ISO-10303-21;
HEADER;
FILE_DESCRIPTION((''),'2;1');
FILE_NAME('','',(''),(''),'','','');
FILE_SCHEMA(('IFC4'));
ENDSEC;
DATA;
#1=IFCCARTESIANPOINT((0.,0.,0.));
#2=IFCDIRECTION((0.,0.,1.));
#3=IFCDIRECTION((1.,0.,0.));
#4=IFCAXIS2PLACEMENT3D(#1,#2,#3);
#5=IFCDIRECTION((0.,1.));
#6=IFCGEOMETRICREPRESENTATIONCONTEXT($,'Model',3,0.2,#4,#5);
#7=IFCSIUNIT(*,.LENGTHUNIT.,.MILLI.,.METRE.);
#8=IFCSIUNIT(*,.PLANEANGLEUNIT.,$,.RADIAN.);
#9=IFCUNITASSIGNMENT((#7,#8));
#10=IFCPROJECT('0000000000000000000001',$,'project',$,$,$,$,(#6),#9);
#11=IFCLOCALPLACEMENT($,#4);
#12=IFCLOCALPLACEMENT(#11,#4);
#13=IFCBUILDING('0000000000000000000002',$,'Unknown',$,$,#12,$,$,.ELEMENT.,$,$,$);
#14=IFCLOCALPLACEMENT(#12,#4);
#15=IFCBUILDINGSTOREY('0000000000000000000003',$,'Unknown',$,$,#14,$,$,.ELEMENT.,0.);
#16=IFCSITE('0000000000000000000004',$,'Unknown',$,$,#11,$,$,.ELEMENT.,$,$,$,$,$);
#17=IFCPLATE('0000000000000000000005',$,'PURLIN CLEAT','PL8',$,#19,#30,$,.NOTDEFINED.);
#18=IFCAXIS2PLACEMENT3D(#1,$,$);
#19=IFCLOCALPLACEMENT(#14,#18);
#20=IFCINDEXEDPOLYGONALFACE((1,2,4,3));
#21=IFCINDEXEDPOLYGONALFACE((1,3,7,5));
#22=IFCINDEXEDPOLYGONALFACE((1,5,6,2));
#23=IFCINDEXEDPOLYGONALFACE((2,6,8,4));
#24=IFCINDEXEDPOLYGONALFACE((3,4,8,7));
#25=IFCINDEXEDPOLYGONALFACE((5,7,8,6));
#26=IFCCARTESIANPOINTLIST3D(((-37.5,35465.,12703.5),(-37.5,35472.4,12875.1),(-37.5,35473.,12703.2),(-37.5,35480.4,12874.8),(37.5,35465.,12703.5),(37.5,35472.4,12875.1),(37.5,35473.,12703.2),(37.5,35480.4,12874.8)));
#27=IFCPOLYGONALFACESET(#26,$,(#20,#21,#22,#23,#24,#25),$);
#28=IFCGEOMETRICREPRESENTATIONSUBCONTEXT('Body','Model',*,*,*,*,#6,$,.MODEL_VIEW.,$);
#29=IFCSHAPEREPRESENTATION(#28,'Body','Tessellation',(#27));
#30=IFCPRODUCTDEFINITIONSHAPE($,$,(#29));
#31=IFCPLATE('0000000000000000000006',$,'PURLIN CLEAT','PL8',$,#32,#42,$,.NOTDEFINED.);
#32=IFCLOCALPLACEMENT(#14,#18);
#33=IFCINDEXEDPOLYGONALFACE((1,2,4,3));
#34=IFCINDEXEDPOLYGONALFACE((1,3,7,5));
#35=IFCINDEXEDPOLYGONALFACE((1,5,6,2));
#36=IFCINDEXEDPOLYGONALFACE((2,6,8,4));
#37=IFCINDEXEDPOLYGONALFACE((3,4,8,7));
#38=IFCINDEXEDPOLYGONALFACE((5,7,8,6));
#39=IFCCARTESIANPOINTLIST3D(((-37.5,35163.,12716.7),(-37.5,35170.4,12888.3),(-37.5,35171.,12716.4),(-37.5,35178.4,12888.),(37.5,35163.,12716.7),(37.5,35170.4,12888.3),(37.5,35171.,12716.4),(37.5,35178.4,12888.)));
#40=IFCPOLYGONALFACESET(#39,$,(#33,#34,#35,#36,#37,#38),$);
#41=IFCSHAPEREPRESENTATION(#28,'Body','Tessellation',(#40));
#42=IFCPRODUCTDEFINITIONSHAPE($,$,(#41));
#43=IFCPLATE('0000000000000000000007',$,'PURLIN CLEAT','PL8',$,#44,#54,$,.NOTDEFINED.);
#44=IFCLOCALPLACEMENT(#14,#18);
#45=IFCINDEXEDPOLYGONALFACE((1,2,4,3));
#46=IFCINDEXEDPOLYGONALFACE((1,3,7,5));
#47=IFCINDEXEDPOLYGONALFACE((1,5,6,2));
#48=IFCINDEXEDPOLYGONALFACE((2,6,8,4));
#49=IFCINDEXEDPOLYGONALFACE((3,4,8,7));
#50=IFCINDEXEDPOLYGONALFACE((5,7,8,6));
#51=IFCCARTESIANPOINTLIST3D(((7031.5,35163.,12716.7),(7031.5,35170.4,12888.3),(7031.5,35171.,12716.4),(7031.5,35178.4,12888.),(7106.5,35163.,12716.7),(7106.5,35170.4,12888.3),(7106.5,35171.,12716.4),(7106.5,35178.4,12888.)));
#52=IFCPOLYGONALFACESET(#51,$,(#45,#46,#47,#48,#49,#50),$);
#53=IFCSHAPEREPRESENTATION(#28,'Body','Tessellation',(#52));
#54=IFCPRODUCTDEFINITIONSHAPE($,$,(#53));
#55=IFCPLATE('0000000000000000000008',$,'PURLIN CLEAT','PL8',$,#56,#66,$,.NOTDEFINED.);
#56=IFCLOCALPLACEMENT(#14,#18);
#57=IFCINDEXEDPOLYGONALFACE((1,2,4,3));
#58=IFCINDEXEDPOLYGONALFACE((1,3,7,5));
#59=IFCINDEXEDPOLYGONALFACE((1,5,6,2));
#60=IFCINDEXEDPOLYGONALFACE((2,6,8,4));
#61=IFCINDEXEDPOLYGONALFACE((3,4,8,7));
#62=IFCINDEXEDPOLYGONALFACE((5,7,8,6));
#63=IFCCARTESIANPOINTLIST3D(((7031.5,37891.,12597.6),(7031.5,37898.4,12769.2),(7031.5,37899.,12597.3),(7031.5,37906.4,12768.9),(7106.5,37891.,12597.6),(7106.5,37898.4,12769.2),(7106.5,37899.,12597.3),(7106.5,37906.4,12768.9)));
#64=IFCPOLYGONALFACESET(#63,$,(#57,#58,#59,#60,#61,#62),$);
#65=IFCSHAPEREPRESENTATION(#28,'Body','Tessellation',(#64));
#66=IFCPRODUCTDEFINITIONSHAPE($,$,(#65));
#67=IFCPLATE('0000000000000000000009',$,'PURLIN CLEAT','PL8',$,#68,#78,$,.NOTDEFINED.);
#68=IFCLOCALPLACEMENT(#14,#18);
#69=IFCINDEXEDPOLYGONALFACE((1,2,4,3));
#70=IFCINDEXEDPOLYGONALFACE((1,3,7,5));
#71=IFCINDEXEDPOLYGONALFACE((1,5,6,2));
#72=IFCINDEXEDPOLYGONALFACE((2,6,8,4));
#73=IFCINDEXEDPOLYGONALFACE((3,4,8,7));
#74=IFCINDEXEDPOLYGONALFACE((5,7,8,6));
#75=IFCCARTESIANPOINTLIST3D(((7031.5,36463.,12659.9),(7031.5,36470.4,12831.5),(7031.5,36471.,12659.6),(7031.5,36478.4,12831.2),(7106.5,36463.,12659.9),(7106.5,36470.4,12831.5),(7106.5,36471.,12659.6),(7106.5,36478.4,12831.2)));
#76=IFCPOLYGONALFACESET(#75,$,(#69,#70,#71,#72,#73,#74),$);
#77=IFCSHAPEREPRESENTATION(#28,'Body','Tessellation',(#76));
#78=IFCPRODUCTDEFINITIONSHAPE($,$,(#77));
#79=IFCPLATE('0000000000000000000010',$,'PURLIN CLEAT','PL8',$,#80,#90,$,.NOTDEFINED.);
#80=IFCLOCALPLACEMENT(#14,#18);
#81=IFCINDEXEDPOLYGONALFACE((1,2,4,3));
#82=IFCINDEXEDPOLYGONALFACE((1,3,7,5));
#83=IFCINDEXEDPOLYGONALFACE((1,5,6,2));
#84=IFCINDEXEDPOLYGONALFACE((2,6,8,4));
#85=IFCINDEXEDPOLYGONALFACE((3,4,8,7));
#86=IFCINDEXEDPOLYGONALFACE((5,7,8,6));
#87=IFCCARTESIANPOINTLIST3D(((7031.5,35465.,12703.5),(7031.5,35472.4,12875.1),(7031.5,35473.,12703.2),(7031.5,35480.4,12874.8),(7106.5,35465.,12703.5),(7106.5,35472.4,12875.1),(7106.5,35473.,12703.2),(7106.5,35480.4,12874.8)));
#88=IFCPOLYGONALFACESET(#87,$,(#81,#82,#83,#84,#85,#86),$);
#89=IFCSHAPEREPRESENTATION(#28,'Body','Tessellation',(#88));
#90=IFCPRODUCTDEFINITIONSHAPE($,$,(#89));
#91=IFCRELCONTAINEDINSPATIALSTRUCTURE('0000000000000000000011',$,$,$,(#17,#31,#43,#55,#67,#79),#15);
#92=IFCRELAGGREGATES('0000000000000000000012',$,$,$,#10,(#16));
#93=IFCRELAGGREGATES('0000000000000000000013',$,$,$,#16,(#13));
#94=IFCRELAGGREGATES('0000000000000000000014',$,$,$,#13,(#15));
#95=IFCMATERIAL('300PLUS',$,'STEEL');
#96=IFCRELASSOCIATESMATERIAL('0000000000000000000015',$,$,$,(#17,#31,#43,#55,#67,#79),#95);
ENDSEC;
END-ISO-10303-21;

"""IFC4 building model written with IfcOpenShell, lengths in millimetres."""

from ifc_helpers import new_model, si_unit, direction, frame, origin_with_axes, place, context, subcontext, project, spatial, line, indexed_curve, outline, extrude, material, element, save


model = new_model("IFC4")

# Units and contexts
model_context = context("Model", 3, precision=0.2, world=origin_with_axes(), true_north=direction((0.0, 1.0)))
body_context = subcontext(model_context, "Body", "Model", "MODEL_VIEW")
ifc_project = project(units=[si_unit("LENGTHUNIT", "METRE", prefix="MILLI"), si_unit("PLANEANGLEUNIT", "RADIAN")], contexts=[model_context])

# Site, building, storey
site_placement = place(None, origin_with_axes())
site = spatial("IfcSite", under=ifc_project, at=site_placement, Name="Unknown", CompositionType="ELEMENT")
building_placement = place(site_placement, origin_with_axes())
building = spatial("IfcBuilding", under=site, at=building_placement, Name="Unknown", CompositionType="ELEMENT")
storey_placement = place(building_placement, origin_with_axes())
storey = spatial("IfcBuildingStorey", under=building, at=storey_placement, Name="Unknown", CompositionType="ELEMENT", Elevation=0.0)

# Plates
ifc_material_1 = material(Name="300PLUS", Category="STEEL")
for number, where, z_axis, x_axis, name in (
    (1, (-37.5, 35469.0, 12703.4), (0.0, -0.999071, 0.043084), (1.0, 0.0, 0.0), "PURLIN CLEAT"),
    (2, (-37.5, 35167.0, 12716.6), (0.0, -0.999071, 0.043084), (1.0, 0.0, 0.0), "PURLIN CLEAT"),
    (3, (7031.5, 35167.0, 12716.6), (0.0, -0.999071, 0.043084), (1.0, 0.0, 0.0), "PURLIN CLEAT"),
    (4, (7031.5, 37895.0, 12597.5), (0.0, -0.999071, 0.043084), (1.0, 0.0, 0.0), "PURLIN CLEAT"),
    (5, (7031.5, 36467.0, 12659.8), (0.0, -0.999071, 0.043084), (1.0, 0.0, 0.0), "PURLIN CLEAT"),
    (6, (7031.5, 35469.0, 12703.4), (0.0, -0.999071, 0.043084), (1.0, 0.0, 0.0), "PURLIN CLEAT"),
):
    element("IfcPlate", number, at=place(storey_placement, frame(where, z_axis=z_axis, x_axis=x_axis)), inside=storey, material=ifc_material_1, Name=name, Description="PL8", PredefinedType="NOTDEFINED", context=body_context, shape_type="SolidModel", body=[
        extrude(outline(indexed_curve([(0.0, 0.0), (75.0, 0.0), (75.0, 171.8), (0.0, 171.8)], segments=[line(1, 2, 3, 4, 1)])), frame((0.0, 0.0, 4.0), z_axis=(0.0, 0.0, 1.0), x_axis=(1.0, 0.0, 0.0)), (0.0, 0.0, -1.0), 8.0),
    ])

save(model, "model.ifc")
